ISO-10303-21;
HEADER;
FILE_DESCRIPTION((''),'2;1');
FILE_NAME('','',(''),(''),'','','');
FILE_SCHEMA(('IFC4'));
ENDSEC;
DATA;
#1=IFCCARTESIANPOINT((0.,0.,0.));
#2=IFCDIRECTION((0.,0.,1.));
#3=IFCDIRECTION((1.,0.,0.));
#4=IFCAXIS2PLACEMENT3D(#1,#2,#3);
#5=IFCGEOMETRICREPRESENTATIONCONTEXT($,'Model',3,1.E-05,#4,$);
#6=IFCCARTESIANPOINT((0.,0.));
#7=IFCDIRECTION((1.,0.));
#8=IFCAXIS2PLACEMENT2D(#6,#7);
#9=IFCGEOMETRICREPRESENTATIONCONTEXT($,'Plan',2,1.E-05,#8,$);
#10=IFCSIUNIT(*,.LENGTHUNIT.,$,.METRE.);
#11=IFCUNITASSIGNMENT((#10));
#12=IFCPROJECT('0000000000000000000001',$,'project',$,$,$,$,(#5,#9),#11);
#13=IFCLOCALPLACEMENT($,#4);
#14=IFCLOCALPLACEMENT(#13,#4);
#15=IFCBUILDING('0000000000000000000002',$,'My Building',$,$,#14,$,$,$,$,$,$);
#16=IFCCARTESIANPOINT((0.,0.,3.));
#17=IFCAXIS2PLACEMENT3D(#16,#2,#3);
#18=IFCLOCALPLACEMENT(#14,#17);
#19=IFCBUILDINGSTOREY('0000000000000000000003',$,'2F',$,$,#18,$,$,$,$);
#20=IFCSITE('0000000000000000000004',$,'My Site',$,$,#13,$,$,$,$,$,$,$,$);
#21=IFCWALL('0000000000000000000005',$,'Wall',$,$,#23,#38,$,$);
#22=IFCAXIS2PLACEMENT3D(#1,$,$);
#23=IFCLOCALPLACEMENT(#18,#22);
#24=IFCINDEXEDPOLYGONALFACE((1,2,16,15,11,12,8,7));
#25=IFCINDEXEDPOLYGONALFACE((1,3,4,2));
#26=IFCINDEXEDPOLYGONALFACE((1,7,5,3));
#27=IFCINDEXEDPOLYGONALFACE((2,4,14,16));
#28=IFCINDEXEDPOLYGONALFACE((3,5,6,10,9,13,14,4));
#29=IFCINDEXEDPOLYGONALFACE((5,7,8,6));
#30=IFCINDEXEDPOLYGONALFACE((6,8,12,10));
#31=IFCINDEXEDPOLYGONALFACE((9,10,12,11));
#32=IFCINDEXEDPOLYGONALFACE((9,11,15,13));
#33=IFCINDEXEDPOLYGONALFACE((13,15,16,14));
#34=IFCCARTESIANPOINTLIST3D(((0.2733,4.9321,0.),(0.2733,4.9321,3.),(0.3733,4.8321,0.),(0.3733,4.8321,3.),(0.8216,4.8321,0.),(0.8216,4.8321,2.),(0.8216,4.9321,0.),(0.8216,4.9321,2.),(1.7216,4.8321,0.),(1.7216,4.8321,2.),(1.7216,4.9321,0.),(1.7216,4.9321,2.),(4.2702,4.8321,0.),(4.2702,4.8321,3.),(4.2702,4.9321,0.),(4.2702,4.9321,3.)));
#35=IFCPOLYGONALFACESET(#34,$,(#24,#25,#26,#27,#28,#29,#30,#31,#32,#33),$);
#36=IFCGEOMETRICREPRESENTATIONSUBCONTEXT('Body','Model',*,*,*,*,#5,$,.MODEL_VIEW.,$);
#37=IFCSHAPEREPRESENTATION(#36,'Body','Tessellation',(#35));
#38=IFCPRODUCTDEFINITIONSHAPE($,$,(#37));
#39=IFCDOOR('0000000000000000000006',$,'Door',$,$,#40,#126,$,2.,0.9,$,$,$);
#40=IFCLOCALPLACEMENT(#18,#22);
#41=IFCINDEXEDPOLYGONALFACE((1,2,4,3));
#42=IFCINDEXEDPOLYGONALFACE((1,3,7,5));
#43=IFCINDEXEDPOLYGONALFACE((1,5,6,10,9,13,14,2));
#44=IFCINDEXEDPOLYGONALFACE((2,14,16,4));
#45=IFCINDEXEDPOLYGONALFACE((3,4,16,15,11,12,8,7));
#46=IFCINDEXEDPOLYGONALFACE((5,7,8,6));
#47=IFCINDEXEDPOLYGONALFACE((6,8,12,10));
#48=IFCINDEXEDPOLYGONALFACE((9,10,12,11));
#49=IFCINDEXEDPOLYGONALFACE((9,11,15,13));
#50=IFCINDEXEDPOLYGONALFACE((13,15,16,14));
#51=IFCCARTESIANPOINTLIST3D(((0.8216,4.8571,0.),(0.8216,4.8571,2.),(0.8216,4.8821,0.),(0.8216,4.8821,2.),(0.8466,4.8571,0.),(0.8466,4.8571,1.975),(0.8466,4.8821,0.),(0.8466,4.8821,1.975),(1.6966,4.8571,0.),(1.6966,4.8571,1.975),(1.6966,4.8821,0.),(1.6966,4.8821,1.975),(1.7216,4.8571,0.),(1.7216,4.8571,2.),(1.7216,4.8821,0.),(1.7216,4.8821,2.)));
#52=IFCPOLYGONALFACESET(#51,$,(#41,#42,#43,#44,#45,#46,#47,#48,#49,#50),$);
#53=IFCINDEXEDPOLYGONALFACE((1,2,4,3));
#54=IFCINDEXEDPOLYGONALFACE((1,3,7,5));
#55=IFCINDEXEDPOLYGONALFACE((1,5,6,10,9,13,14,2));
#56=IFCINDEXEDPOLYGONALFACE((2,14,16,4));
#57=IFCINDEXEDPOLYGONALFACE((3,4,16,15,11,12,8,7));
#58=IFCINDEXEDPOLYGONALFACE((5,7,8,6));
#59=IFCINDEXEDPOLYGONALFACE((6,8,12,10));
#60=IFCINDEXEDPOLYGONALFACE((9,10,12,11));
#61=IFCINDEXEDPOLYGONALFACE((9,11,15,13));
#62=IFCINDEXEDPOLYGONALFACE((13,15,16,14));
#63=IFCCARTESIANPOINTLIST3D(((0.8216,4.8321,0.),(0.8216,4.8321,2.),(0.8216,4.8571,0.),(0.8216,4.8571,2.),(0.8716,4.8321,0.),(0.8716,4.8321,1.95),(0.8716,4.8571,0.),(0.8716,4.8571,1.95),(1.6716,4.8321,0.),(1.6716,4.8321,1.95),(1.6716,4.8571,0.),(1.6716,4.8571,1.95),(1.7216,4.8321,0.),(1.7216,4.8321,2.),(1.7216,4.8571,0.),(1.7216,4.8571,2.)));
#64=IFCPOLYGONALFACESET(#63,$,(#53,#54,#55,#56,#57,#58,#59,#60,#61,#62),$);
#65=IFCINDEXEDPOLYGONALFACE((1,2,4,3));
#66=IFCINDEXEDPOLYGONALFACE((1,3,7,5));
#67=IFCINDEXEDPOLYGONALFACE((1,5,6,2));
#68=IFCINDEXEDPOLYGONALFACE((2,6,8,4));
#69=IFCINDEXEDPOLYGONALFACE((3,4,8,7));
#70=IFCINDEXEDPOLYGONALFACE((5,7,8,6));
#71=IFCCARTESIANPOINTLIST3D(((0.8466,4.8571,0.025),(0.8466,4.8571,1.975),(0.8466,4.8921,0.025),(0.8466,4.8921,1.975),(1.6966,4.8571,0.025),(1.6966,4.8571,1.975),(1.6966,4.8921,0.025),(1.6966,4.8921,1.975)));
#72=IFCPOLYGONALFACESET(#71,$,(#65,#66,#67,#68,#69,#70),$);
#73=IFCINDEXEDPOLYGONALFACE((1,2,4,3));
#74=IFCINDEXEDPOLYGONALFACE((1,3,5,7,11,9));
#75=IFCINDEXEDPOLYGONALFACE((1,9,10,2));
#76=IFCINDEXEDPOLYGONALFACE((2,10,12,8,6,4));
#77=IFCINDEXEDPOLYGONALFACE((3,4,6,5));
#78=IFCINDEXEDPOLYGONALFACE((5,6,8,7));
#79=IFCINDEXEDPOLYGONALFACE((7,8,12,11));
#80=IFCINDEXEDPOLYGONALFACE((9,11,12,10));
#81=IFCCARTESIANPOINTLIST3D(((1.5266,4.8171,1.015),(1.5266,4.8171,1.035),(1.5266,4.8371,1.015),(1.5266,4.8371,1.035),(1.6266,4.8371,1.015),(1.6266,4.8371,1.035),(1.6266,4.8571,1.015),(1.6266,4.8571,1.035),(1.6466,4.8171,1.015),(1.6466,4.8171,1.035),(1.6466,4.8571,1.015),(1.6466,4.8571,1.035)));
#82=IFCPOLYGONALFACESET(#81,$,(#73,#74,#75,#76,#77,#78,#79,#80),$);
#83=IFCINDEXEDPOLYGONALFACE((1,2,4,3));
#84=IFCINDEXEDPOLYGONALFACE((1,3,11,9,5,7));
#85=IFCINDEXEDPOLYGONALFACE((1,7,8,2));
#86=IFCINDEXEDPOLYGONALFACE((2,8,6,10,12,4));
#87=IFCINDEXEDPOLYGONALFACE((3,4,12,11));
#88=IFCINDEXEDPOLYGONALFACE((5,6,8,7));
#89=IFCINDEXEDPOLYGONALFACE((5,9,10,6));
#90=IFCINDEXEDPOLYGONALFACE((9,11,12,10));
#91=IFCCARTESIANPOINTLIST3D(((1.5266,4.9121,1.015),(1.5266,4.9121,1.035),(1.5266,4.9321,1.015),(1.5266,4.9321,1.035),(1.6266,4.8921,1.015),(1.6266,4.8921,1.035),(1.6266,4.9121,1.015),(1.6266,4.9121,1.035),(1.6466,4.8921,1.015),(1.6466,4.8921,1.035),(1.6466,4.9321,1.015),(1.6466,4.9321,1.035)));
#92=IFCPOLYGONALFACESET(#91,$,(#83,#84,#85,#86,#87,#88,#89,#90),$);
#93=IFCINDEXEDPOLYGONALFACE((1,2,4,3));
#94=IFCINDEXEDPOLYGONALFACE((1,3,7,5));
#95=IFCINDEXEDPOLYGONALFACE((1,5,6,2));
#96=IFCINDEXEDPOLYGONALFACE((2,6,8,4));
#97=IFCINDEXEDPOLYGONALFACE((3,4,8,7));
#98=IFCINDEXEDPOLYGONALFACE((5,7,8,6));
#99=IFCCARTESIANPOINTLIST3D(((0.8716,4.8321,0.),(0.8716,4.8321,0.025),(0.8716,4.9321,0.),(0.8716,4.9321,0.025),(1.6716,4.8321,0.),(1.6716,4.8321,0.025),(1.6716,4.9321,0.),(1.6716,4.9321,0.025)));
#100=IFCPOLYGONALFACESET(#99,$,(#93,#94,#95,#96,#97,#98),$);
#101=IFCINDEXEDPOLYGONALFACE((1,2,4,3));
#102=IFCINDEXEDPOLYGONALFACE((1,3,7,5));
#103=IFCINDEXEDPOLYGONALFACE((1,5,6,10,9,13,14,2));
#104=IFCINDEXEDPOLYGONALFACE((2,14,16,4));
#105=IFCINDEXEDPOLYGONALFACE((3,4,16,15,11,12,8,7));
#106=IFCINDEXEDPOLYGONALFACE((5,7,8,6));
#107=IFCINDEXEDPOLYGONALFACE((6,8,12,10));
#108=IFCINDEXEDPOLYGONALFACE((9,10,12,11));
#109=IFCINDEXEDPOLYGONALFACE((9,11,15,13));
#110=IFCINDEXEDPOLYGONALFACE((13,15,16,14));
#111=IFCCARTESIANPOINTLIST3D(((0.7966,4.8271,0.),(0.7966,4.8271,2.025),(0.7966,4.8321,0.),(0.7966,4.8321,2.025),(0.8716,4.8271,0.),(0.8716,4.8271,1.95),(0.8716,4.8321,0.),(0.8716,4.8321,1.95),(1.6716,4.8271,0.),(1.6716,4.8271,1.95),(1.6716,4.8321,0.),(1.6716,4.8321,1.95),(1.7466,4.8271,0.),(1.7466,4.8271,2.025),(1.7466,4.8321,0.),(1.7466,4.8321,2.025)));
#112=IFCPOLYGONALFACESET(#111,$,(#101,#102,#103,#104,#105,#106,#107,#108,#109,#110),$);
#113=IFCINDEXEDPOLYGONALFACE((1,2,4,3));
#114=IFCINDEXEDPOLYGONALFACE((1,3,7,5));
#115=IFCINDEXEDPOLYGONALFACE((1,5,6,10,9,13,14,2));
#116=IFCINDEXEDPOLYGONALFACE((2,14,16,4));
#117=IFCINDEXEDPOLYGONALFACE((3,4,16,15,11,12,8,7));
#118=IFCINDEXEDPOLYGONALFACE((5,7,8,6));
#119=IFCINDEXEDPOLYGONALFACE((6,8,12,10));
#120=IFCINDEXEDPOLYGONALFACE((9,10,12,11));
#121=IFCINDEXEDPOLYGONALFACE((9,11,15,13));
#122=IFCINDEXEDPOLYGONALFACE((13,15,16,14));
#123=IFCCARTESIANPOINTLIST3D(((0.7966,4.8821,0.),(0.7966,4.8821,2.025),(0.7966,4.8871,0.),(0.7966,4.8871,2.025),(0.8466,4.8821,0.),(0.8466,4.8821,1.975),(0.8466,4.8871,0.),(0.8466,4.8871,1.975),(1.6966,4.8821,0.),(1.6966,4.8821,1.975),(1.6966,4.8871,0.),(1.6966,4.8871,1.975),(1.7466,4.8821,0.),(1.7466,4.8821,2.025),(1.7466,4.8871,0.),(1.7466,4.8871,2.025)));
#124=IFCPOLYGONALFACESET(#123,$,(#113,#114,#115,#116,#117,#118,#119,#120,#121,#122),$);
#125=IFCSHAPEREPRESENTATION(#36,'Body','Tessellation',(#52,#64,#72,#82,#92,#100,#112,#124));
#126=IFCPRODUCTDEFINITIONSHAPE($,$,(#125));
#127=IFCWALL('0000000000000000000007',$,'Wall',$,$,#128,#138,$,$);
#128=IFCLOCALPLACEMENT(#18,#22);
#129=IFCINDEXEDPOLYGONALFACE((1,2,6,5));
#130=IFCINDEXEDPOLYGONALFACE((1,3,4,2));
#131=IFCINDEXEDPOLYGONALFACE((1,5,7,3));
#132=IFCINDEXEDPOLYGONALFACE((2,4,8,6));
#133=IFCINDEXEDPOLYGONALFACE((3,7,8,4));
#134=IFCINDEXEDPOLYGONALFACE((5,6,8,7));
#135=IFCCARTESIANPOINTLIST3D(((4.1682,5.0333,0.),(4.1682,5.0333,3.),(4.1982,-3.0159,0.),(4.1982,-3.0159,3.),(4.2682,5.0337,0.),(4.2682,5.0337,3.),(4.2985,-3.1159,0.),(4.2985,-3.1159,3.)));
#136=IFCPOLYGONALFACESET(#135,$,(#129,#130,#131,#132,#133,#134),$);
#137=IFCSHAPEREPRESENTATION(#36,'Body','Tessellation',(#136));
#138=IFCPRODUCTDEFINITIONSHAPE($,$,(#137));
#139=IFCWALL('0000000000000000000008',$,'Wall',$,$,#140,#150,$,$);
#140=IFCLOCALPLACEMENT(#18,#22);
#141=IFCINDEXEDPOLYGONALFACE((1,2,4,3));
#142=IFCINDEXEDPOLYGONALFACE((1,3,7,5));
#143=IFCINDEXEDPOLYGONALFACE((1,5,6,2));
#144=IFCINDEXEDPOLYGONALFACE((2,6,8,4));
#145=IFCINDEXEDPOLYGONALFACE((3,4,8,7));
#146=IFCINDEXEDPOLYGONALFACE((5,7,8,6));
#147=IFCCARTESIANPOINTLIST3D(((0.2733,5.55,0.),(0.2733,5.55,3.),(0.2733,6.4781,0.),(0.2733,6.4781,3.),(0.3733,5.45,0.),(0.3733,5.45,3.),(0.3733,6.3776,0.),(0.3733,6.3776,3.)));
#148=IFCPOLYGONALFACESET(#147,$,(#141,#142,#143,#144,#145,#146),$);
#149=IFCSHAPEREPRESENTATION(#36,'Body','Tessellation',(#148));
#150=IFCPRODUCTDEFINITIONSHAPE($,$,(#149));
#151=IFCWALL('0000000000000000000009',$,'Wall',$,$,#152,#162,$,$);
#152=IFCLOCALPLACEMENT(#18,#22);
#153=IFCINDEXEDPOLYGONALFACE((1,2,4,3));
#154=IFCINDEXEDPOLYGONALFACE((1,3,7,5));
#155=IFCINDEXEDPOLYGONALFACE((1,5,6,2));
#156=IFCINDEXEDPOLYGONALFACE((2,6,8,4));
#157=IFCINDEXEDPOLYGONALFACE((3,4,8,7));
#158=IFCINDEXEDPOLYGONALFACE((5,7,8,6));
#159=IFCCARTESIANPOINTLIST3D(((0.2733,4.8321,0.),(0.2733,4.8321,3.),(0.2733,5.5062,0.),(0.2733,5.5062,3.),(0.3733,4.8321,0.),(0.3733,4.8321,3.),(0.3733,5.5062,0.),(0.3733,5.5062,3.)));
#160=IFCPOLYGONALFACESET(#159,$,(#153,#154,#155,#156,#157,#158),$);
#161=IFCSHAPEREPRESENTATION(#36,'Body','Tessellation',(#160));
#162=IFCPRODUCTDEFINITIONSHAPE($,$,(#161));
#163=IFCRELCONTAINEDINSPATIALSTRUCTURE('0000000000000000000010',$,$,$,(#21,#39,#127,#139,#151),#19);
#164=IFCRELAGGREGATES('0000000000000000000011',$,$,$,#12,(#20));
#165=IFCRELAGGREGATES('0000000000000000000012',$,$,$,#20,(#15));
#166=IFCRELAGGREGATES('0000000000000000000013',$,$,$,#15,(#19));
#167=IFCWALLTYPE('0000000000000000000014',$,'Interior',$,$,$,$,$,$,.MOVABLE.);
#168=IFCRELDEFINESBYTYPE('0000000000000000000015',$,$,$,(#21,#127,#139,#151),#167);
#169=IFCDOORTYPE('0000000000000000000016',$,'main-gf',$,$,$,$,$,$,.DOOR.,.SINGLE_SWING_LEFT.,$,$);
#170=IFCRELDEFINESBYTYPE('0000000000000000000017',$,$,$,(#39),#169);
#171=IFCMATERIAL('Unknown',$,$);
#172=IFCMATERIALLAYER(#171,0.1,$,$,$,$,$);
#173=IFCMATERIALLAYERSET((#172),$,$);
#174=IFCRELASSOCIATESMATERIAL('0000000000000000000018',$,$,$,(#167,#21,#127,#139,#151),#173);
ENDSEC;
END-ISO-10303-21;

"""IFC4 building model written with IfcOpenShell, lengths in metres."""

from ifc_helpers import new_model, entity, si_unit, frame, origin_with_axes, origin_2d_with_axis, place, context, subcontext, project, spatial, line, indexed_curve, outline, extrude, shape, source, transform, mapped, material, layer, layer_set, layer_usage, type_object, type_shapes, element, fill, save


model = new_model("IFC4")

# Units and contexts
model_context = context("Model", 3, precision=1e-05, world=origin_with_axes())
plan_context = context("Plan", 2, precision=1e-05, world=origin_2d_with_axis())
body_context_1 = subcontext(model_context, "Body", "Model", "MODEL_VIEW")
body_context_2 = subcontext(plan_context, "Body", "Plan", "PLAN_VIEW")
ifc_project = project(units=[si_unit("LENGTHUNIT", "METRE")], contexts=[model_context, plan_context])

# Site, building, storey
site_placement = place(None, origin_with_axes())
site = spatial("IfcSite", under=ifc_project, at=site_placement, Name="My Site")
building_placement = place(site_placement, origin_with_axes())
building = spatial("IfcBuilding", under=site, at=building_placement, Name="My Building")
storey_placement = place(building_placement, frame((0.0, 0.0, 3.0), z_axis=(0.0, 0.0, 1.0), x_axis=(1.0, 0.0, 0.0)))
storey = spatial("IfcBuildingStorey", under=building, at=storey_placement, Name="2F")

# Shared definitions
ifc_material = material(Name="Unknown")

# Shared definitions
ifc_layer_1 = layer(ifc_material, 0.1)
ifc_layer_set_1 = layer_set([ifc_layer_1])
wall_type = type_object("IfcWallType", Name="Interior", PredefinedType="MOVABLE", material=ifc_layer_set_1)

# Wall, opening, door
ifc_layer_usage_1 = layer_usage(ifc_layer_set_1, "AXIS2", "POSITIVE", 0.0)
wall_1_placement = place(storey_placement, frame((4.2702, 4.9321, 0.0), z_axis=(0.0, 0.0, 1.0), x_axis=(-1.0, 0.0, 0.0)))
wall_1 = element("IfcWall", 1, at=wall_1_placement, inside=storey, type_object=wall_type, material=ifc_layer_usage_1, Name="Wall", context=body_context_1, shape_type="SweptSolid", body=[
    extrude(outline(indexed_curve([(0.0, 0.0), (0.0, 0.1), (3.8969, 0.1), (3.9969, 0.0)], segments=[line(1, 2, 3, 4, 1)])), origin_with_axes(), (0.0, 0.0, 1.0), 3.0),
])
shared_shape_1 = source(origin_with_axes(), body_context_1, "Body", "SweptSolid", [
    extrude(outline(indexed_curve([(0.0, 0.0), (0.9, 0.0), (0.9, 2.0), (0.0, 2.0)], segments=[line(1, 2, 3, 4, 1)])), frame((0.0, -0.6, 0.0), z_axis=(0.0, -1.0, 0.0), x_axis=(1.0, 0.0, 0.0)), (0.0, 0.0, -1.0), 1.2),
])
opening_1_placement = place(wall_1_placement, frame((3.4486, 0.1, 0.0), z_axis=(0.0, 0.0, 1.0), x_axis=(-1.0, 0.0, 0.0)))
opening_1 = element("IfcOpeningElement", 2, at=opening_1_placement, cuts=wall_1, PredefinedType="OPENING", context=body_context_1, shape_type="MappedRepresentation", body=[
    mapped(shared_shape_1, transform((0.0, 0.0, 0.0), x_axis=(1.0, 0.0, 0.0), y_axis=(0.0, 1.0, 0.0), z_axis=(0.0, 0.0, 1.0), scale=1.0)),
])
door_type = type_object("IfcDoorType", Name="main-gf", OperationType="SINGLE_SWING_LEFT", PredefinedType="DOOR")
shared_shape_2 = source(origin_with_axes(), body_context_1, "Body", "SweptSolid", [
    extrude(outline(indexed_curve([(0.0, 0.0), (0.0, 2.0), (0.9, 2.0), (0.9, 0.0), (0.875, 0.0), (0.875, 1.975), (0.025, 1.975), (0.025, 0.0)], segments=[line(1, 2, 3, 4, 5, 6, 7, 8, 1)])), frame((0.0, 0.025, 0.0), z_axis=(0.0, -1.0, 0.0), x_axis=(1.0, 0.0, 0.0)), (0.0, 0.0, -1.0), 0.025),
    extrude(outline(indexed_curve([(0.0, 0.0), (0.0, 2.0), (0.9, 2.0), (0.9, 0.0), (0.85, 0.0), (0.85, 1.95), (0.05, 1.95), (0.05, 0.0)], segments=[line(1, 2, 3, 4, 5, 6, 7, 8, 1)])), frame((0.0, 0.0, 0.0), z_axis=(0.0, -1.0, 0.0), x_axis=(1.0, 0.0, 0.0)), (0.0, 0.0, -1.0), 0.025),
    extrude(outline(indexed_curve([(0.0, 0.0), (0.85, 0.0), (0.85, 0.035), (0.0, 0.035)], segments=[line(1, 2, 3, 4, 1)])), frame((0.025, 0.025, 0.025), z_axis=(0.0, 0.0, 1.0), x_axis=(1.0, 0.0, 0.0)), (0.0, 0.0, 1.0), 1.95),
    extrude(outline(indexed_curve([(0.0, 0.0), (0.0, -0.04), (-0.12, -0.04), (-0.12, -0.02), (-0.02, -0.02), (-0.02, 0.0)], segments=[line(1, 2, 3, 4, 5, 6, 1)])), frame((0.825, 0.025, 1.015), z_axis=(0.0, 0.0, 1.0), x_axis=(1.0, 0.0, 0.0)), (0.0, 0.0, 1.0), 0.02),
    extrude(outline(indexed_curve([(0.0, 0.0), (0.0, 0.04), (-0.12, 0.04), (-0.12, 0.02), (-0.02, 0.02), (-0.02, 0.0)], segments=[line(1, 2, 3, 4, 5, 6, 1)])), frame((0.825, 0.06, 1.015), z_axis=(0.0, 0.0, 1.0), x_axis=(1.0, 0.0, 0.0)), (0.0, 0.0, 1.0), 0.02),
    extrude(outline(indexed_curve([(0.0, 0.0), (0.8, 0.0), (0.8, 0.1), (0.0, 0.1)], segments=[line(1, 2, 3, 4, 1)])), frame((0.05, 0.0, 0.0), z_axis=(0.0, 0.0, 1.0), x_axis=(1.0, 0.0, 0.0)), (0.0, 0.0, 1.0), 0.025),
    extrude(outline(indexed_curve([(0.0, 0.0), (0.0, 2.025), (0.95, 2.025), (0.95, 0.0), (0.875, 0.0), (0.875, 1.95), (0.075, 1.95), (0.075, 0.0)], segments=[line(1, 2, 3, 4, 5, 6, 7, 8, 1)])), frame((-0.025, -0.005, 0.0), z_axis=(0.0, -1.0, 0.0), x_axis=(1.0, 0.0, 0.0)), (0.0, 0.0, -1.0), 0.005),
    extrude(outline(indexed_curve([(0.0, 0.0), (0.0, 2.025), (0.95, 2.025), (0.95, 0.0), (0.9, 0.0), (0.9, 1.975), (0.05, 1.975), (0.05, 0.0)], segments=[line(1, 2, 3, 4, 5, 6, 7, 8, 1)])), frame((-0.025, 0.05, 0.0), z_axis=(0.0, -1.0, 0.0), x_axis=(1.0, 0.0, 0.0)), (0.0, 0.0, -1.0), 0.005),
])
shared_shape_3 = source(origin_with_axes(), body_context_2, "Body", "Curve2D", [
    entity("IfcIndexedPolyCurve", entity("IfcCartesianPointList2D", [[0.0, 0.0], [0.0, 0.05], [0.025, 0.05], [0.025, 0.025], [0.05, 0.025], [0.05, 0.0]]), [entity("IfcLineIndex", [1, 2, 3, 4, 5, 6, 1])]),
    entity("IfcIndexedPolyCurve", entity("IfcCartesianPointList2D", [[0.9, 0.0], [0.9, 0.05], [0.875, 0.05], [0.875, 0.025], [0.85, 0.025], [0.85, 0.0]]), [entity("IfcLineIndex", [1, 2, 3, 4, 5, 6, 1])]),
    entity("IfcTrimmedCurve", entity("IfcEllipse", entity("IfcAxis2Placement2D", entity("IfcCartesianPoint", [0.06, 0.05]), entity("IfcDirection", [1.0, 0.0])), 0.815, 0.85), [entity("IfcCartesianPoint", [0.875, 0.05])], [entity("IfcCartesianPoint", [0.06, 0.9])], True, "CARTESIAN"),
    entity("IfcIndexedPolyCurve", entity("IfcCartesianPointList2D", [[0.025, 0.05], [0.06, 0.05], [0.06, 0.9], [0.025, 0.9]]), [entity("IfcLineIndex", [1, 2, 3, 4, 1])]),
])
type_shapes(door_type, [shared_shape_2, shared_shape_3])
door_placement = place(opening_1_placement, frame((0.0, 0.0, 0.0), z_axis=(0.0, 0.0, 1.0), x_axis=(1.0, 0.0, 0.0)))
door = element("IfcDoor", 3, at=door_placement, inside=storey, type_object=door_type, Name="Door", OverallHeight=2.0, OverallWidth=0.9, shapes=[
    shape(body_context_1, "Body", "MappedRepresentation", [mapped(shared_shape_2, transform((0.0, 0.0, 0.0), x_axis=(1.0, 0.0, 0.0), y_axis=(0.0, 1.0, 0.0), z_axis=(0.0, 0.0, 1.0), scale=1.0))]),
    shape(body_context_2, "Body", "MappedRepresentation", [mapped(shared_shape_3, transform((0.0, 0.0, 0.0), x_axis=(1.0, 0.0, 0.0), y_axis=(0.0, 1.0, 0.0), z_axis=(0.0, 0.0, 1.0), scale=1.0))]),
])
fill(opening_1, door)

# Walls
ifc_layer_usage_2 = layer_usage(ifc_layer_set_1, "AXIS2", "POSITIVE", 0.0)
wall_2_placement = place(storey_placement, frame((4.1682, 5.0333, 0.0), z_axis=(0.0, 0.0, 1.0), x_axis=(0.00372, -0.999993, 0.0)))
element("IfcWall", 4, at=wall_2_placement, inside=storey, type_object=wall_type, material=ifc_layer_usage_2, Name="Wall", context=body_context_1, shape_type="SweptSolid", body=[
    extrude(outline(indexed_curve([(0.0, 0.0), (0.0, 0.1), (8.1496, 0.1), (8.0492, 0.0)], segments=[line(1, 2, 3, 4, 1)])), origin_with_axes(), (0.0, 0.0, 1.0), 3.0),
])
ifc_layer_usage_3 = layer_usage(ifc_layer_set_1, "AXIS2", "POSITIVE", 0.0)
wall_3_placement = place(storey_placement, frame((0.3733, 5.55, 0.0), z_axis=(0.0, 0.0, 1.0), x_axis=(0.0, 1.0, 0.0)))
element("IfcWall", 5, at=wall_3_placement, inside=storey, type_object=wall_type, material=ifc_layer_usage_3, Name="Wall", context=body_context_1, shape_type="SweptSolid", body=[
    extrude(outline(indexed_curve([(-0.1, 0.0), (0.0, 0.1), (0.9281, 0.1), (0.8276, 0.0)], segments=[line(1, 2, 3, 4, 1)])), origin_with_axes(), (0.0, 0.0, 1.0), 3.0),
])
ifc_layer_usage_4 = layer_usage(ifc_layer_set_1, "AXIS2", "POSITIVE", 0.0)
wall_4_placement = place(storey_placement, frame((0.3733, 4.8321, 0.0), z_axis=(0.0, 0.0, 1.0), x_axis=(0.0, 1.0, 0.0)))
element("IfcWall", 6, at=wall_4_placement, inside=storey, type_object=wall_type, material=ifc_layer_usage_4, Name="Wall", context=body_context_1, shape_type="SweptSolid", body=[
    extrude(outline(indexed_curve([(0.0, 0.0), (0.0, 0.1), (0.674, 0.1), (0.674, 0.0)], segments=[line(1, 2, 3, 4, 1)])), origin_with_axes(), (0.0, 0.0, 1.0), 3.0),
])

save(model, "model.ifc")
